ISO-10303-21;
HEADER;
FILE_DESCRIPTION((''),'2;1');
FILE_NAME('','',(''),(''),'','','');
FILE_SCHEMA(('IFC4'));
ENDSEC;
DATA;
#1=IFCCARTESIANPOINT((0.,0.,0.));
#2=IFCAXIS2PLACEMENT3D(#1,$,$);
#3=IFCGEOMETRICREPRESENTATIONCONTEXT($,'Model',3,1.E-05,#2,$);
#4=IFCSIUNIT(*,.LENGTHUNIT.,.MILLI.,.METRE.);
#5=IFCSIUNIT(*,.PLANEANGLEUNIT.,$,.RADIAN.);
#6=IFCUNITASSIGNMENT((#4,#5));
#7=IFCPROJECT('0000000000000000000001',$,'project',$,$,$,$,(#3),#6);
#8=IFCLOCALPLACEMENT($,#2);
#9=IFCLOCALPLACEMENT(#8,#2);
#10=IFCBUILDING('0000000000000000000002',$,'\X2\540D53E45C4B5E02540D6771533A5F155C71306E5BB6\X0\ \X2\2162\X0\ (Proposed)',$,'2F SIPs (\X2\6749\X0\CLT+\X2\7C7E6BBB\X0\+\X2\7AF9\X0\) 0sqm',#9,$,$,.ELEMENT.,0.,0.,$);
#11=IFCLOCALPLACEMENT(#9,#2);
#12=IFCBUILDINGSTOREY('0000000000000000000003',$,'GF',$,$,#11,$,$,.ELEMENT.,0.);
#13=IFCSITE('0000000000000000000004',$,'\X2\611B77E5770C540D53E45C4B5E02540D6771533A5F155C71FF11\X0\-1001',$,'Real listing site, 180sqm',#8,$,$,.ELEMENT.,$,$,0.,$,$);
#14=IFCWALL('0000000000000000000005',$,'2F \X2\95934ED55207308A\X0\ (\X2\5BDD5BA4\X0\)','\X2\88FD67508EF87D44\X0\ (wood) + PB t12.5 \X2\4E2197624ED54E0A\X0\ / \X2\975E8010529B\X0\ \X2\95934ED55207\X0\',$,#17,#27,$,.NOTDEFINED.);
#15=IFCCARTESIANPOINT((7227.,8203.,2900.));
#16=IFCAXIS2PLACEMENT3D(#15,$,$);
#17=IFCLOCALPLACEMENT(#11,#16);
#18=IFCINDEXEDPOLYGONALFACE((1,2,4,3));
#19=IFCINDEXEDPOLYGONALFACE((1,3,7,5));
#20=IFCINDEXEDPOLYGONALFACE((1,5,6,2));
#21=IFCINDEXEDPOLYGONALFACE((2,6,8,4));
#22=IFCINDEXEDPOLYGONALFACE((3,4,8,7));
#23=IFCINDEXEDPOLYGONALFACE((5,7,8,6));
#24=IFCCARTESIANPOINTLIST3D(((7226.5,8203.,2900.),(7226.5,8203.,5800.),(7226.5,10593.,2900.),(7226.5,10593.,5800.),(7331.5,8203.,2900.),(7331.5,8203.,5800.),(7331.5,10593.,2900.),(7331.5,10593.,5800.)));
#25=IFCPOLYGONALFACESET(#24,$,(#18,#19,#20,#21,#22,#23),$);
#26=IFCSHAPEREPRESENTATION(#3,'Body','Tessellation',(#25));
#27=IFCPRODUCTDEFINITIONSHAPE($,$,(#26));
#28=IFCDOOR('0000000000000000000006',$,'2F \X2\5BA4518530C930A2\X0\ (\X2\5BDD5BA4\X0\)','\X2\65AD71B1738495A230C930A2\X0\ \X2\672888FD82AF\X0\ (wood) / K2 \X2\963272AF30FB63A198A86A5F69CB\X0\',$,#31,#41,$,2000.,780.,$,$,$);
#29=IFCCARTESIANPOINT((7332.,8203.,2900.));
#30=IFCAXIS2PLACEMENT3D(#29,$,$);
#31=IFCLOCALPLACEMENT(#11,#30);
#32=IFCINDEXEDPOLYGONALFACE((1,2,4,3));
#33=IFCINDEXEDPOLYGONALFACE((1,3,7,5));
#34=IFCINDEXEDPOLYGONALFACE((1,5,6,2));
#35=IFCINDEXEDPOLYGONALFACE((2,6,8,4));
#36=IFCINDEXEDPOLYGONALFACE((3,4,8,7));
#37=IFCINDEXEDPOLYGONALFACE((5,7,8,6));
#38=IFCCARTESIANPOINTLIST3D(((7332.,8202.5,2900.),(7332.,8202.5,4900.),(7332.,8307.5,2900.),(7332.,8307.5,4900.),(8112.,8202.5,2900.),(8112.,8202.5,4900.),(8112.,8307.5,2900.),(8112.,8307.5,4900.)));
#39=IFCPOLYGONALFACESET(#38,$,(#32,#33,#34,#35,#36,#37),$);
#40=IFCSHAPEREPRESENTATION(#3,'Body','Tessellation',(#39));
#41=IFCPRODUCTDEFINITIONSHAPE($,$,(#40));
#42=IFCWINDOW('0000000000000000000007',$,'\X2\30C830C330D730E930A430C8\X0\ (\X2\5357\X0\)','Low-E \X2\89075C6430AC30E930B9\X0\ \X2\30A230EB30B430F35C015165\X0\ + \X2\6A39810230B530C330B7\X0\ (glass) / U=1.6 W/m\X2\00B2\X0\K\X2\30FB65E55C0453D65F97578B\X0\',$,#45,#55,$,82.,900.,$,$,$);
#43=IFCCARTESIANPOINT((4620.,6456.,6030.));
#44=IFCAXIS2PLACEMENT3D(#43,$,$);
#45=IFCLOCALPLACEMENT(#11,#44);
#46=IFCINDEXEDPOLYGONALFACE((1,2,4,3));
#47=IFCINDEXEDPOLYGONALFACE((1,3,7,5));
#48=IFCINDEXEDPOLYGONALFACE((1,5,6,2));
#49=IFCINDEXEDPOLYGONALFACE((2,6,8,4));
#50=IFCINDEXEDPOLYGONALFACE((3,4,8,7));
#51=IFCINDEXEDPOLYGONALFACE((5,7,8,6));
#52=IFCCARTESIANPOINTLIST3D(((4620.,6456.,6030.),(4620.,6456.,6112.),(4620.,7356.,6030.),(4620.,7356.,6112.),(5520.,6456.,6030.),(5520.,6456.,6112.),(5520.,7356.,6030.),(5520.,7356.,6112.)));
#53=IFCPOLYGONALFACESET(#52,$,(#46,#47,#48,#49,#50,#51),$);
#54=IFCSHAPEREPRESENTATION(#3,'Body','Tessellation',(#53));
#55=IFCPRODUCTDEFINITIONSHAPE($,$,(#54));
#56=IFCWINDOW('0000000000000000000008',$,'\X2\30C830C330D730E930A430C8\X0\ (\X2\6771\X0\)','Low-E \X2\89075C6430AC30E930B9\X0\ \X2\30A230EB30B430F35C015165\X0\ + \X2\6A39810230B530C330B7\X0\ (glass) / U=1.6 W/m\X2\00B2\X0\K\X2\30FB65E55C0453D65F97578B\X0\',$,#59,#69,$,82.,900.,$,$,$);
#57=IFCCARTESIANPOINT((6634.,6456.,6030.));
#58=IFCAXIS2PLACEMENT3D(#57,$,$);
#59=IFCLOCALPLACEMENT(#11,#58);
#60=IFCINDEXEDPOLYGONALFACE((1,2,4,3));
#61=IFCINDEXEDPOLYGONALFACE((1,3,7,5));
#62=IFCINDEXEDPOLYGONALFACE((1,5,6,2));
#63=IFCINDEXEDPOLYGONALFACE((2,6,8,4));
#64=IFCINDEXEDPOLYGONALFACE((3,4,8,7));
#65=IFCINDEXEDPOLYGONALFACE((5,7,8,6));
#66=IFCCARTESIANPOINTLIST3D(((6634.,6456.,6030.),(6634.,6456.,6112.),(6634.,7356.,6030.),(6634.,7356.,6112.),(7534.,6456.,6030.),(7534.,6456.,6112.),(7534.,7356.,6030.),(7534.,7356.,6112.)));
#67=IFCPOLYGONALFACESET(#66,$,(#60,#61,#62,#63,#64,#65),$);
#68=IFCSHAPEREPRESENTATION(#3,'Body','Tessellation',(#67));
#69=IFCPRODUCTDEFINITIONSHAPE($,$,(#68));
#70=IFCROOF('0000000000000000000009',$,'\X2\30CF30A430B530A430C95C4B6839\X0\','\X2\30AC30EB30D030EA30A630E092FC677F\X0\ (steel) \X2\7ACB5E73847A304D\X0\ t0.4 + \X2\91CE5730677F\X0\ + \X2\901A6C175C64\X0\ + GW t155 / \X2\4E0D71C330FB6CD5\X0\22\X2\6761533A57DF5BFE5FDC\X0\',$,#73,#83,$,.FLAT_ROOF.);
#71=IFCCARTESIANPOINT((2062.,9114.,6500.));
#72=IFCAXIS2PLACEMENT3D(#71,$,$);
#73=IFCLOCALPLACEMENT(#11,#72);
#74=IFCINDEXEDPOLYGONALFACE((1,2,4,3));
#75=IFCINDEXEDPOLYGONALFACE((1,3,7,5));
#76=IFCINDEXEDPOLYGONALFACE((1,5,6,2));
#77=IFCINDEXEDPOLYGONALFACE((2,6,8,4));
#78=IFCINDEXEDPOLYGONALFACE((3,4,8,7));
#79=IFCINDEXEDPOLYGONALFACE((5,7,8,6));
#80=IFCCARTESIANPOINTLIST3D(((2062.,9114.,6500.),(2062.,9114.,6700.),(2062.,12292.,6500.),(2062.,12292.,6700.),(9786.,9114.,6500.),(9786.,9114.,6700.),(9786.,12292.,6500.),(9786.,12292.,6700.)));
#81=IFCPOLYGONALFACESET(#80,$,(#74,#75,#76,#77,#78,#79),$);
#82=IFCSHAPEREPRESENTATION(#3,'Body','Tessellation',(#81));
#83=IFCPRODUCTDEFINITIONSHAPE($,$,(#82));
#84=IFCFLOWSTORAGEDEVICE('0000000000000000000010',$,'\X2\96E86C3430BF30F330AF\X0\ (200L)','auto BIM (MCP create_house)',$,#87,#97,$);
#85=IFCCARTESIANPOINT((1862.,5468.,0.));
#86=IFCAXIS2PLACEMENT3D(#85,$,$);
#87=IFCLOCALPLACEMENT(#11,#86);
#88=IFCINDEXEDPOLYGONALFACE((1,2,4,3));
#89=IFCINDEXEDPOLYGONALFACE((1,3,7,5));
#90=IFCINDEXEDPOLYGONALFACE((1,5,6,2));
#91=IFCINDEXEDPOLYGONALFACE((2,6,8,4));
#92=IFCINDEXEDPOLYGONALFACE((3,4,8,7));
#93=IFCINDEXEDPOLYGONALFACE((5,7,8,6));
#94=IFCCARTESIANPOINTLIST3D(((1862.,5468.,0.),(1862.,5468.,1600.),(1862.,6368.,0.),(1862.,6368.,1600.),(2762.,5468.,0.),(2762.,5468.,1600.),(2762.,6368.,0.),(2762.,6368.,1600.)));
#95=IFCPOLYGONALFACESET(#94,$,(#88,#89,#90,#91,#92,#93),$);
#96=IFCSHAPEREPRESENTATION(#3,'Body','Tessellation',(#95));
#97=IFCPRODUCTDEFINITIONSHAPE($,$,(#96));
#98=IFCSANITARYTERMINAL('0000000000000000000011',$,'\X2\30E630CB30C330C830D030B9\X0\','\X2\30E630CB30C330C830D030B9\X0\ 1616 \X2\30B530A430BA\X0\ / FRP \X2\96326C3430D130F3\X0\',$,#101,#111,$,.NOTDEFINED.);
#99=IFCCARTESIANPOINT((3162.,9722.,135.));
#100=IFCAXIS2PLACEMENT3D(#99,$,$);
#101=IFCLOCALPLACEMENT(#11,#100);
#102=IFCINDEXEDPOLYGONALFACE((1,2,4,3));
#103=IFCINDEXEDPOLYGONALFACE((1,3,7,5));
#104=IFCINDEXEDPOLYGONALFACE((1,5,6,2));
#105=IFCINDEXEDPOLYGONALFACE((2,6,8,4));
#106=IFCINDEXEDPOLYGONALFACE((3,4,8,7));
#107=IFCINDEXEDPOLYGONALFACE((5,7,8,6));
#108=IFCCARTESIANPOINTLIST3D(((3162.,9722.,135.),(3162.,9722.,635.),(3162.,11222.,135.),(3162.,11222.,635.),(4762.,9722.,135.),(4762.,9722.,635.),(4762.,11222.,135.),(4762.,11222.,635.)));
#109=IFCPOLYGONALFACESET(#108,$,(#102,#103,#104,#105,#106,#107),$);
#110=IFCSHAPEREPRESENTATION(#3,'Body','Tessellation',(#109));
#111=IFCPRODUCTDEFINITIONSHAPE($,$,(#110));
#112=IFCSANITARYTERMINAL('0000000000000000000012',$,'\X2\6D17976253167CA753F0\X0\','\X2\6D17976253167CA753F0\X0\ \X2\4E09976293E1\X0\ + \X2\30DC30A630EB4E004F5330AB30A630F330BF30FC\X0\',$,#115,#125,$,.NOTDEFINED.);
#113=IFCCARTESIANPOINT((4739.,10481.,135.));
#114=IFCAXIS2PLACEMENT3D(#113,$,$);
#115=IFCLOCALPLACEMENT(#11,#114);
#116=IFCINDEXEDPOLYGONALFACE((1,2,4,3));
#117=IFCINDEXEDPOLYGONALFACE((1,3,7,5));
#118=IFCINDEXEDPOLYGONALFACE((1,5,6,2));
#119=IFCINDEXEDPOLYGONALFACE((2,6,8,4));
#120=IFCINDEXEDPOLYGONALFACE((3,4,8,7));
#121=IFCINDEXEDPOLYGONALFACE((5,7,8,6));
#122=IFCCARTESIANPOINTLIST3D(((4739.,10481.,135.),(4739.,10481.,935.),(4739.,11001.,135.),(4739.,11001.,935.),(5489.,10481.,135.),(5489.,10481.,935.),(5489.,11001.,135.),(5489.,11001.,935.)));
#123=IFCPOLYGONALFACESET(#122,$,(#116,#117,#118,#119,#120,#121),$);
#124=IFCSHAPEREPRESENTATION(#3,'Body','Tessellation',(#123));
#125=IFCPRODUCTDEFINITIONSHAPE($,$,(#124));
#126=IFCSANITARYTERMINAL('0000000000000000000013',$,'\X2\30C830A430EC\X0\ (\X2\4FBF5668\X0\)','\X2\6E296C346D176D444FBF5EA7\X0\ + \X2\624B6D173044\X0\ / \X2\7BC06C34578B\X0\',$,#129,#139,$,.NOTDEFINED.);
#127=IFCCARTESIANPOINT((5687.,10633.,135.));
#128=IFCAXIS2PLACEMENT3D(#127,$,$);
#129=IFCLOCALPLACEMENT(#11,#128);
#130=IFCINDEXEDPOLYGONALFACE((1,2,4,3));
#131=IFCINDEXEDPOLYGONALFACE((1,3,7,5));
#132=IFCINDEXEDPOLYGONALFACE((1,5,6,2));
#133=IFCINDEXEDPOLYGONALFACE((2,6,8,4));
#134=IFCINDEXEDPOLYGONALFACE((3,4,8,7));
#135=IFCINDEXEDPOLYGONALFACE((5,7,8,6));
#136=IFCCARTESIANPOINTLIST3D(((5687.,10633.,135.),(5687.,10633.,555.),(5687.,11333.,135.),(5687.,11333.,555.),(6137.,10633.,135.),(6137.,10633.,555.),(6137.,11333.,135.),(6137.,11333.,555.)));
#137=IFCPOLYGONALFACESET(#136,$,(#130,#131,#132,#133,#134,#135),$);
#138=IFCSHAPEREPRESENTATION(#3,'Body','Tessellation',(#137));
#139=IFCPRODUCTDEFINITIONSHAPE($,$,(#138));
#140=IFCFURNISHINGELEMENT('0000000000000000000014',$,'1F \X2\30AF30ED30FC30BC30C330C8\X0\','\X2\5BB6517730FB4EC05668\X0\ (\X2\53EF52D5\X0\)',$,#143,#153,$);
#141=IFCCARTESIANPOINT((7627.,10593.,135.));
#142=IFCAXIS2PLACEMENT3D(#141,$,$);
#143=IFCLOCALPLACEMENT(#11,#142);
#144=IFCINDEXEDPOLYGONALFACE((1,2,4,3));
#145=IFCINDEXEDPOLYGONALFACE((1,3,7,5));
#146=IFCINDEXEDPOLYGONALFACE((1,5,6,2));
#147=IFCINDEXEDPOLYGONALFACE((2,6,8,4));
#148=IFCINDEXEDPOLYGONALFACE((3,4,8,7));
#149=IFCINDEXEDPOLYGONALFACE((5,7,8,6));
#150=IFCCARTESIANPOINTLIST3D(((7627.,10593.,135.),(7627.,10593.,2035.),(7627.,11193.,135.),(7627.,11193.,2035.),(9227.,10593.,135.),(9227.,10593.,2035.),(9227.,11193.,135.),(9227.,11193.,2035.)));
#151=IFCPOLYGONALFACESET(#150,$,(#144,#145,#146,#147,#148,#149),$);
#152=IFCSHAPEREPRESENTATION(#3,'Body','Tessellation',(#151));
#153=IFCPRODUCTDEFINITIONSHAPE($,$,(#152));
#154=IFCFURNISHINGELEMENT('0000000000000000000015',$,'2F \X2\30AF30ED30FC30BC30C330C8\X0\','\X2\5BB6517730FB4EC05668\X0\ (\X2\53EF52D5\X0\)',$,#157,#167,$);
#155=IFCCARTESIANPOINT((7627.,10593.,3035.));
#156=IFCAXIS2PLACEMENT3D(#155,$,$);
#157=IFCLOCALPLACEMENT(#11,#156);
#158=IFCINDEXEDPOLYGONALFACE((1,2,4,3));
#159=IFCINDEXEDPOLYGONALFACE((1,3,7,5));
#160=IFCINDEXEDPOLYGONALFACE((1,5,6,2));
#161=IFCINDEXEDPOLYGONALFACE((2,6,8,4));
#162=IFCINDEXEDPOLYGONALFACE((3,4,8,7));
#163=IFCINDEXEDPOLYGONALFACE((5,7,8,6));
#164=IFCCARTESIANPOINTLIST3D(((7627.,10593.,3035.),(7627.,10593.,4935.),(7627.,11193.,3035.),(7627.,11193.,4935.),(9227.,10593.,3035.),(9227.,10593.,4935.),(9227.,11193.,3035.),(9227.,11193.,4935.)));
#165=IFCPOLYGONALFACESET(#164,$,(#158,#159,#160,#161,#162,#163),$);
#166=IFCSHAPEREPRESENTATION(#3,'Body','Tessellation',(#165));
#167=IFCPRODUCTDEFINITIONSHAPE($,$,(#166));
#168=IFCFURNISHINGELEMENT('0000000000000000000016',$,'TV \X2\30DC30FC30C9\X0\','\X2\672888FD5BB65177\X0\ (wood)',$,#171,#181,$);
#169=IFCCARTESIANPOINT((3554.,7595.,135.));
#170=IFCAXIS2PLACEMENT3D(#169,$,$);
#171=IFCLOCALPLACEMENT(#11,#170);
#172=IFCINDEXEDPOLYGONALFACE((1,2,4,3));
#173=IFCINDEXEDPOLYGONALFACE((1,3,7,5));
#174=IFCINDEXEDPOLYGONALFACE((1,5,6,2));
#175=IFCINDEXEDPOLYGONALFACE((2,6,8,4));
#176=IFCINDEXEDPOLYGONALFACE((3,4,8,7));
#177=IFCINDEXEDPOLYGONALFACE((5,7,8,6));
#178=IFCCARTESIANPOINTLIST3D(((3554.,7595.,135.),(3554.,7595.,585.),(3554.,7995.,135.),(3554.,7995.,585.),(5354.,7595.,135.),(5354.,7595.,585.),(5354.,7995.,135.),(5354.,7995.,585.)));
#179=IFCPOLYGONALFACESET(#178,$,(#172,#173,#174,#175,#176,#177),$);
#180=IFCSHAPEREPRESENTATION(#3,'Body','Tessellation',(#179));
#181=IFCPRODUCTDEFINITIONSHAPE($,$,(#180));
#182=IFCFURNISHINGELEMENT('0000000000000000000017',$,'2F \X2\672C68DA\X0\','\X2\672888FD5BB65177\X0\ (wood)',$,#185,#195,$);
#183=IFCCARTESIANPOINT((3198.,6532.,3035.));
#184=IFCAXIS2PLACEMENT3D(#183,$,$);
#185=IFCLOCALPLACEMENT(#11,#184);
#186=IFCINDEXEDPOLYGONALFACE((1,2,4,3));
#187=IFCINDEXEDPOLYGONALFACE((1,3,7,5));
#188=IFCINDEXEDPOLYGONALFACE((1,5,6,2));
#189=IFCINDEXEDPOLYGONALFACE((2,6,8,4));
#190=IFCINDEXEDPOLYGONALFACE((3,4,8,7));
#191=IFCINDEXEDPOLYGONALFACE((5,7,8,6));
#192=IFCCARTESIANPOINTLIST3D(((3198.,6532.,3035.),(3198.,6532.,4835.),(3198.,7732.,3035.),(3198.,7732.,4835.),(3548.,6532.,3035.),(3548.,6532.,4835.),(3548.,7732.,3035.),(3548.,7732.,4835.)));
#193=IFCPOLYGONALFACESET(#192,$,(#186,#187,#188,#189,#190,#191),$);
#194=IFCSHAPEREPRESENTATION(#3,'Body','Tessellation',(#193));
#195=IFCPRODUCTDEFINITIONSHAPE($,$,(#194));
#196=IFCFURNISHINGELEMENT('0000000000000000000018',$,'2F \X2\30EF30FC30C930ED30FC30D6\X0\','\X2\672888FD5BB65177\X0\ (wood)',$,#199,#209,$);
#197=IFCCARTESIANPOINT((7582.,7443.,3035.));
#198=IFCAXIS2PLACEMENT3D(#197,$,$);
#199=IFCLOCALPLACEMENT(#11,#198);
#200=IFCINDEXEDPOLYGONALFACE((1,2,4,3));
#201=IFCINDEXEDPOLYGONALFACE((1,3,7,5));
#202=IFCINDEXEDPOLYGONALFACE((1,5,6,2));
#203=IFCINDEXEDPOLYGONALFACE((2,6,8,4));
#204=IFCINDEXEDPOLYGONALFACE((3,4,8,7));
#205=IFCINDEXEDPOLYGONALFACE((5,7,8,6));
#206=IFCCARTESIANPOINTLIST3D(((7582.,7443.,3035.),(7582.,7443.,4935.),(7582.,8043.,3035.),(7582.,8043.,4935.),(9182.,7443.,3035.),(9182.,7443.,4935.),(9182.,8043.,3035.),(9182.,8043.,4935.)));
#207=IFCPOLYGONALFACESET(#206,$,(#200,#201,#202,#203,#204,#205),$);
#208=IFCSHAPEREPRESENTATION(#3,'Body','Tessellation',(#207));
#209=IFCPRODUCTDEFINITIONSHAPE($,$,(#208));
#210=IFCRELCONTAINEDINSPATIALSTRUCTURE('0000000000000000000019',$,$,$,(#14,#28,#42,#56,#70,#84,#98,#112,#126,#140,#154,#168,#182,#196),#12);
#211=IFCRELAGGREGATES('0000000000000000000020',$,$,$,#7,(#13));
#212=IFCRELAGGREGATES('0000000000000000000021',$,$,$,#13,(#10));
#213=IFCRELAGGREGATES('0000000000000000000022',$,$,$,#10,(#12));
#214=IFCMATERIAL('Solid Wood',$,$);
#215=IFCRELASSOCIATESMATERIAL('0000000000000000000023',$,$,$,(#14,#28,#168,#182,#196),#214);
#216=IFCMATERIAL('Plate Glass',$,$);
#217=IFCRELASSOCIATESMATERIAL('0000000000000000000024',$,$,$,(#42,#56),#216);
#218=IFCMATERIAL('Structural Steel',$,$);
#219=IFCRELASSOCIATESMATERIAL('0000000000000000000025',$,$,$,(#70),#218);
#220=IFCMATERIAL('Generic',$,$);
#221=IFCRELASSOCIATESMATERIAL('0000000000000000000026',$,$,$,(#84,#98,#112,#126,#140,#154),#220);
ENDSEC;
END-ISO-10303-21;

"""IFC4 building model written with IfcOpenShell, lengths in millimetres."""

from ifc_helpers import new_model, si_unit, frame, frame_2d, origin, place, context, project, spatial, rectangle, extrude, material, element, save


model = new_model("IFC4")

# Units and contexts
model_context = context("Model", 3, precision=1e-05, world=origin())
ifc_project = project(units=[si_unit("LENGTHUNIT", "METRE", prefix="MILLI"), si_unit("PLANEANGLEUNIT", "RADIAN")], contexts=[model_context])

# Site, building, storey
site_placement = place(None, origin())
site = spatial("IfcSite", under=ifc_project, at=site_placement, Name="愛知県名古屋市名東区引山１-1001", ObjectType="Real listing site, 180sqm", CompositionType="ELEMENT", RefElevation=0.0)
building_placement = place(site_placement, origin())
building = spatial("IfcBuilding", under=site, at=building_placement, Name="名古屋市名東区引山の家 Ⅲ (Proposed)", ObjectType="2F SIPs (杉CLT+籾殻+竹) 0sqm", CompositionType="ELEMENT", ElevationOfRefHeight=0.0, ElevationOfTerrain=0.0)
storey_placement = place(building_placement, origin())
storey = spatial("IfcBuildingStorey", under=building, at=storey_placement, Name="GF", CompositionType="ELEMENT", Elevation=0.0)

# Shared definitions
ifc_material_1 = material(Name="Solid Wood")
ifc_material_2 = material(Name="Plate Glass")

# Wall
wall_1_placement = place(storey_placement, frame((7227.0, 8203.0, 2900.0)))
element("IfcWall", 1, at=wall_1_placement, inside=storey, material=ifc_material_1, Name="2F 間仕切り (寝室)", Description="製材軸組 (wood) + PB t12.5 両面仕上 / 非耐力 間仕切", PredefinedType="NOTDEFINED", context=model_context, shape_type="SweptSolid", body=[
    extrude(rectangle(XDim=105.0, YDim=2390.0, at=frame_2d((52.0, 1195.0))), frame((7227.0, 8203.0, 2900.0)), (0.0, 0.0, 1.0), 2900.0),
])

# Door
door_1_placement = place(storey_placement, frame((7332.0, 8203.0, 2900.0)))
element("IfcDoor", 2, at=door_1_placement, inside=storey, material=ifc_material_1, Name="2F 室内ドア (寝室)", Description="断熱玄関ドア 木製芯 (wood) / K2 防犯・採風機構", OverallHeight=2000.0, OverallWidth=780.0, context=model_context, shape_type="SweptSolid", body=[
    extrude(rectangle(XDim=780.0, YDim=105.0, at=frame_2d((390.0, 52.0))), frame((7332.0, 8203.0, 2900.0)), (0.0, 0.0, 1.0), 2000.0),
])

# Windows
window_1_placement = place(storey_placement, frame((4620.0, 6456.0, 6030.0)))
element("IfcWindow", 3, at=window_1_placement, inside=storey, material=ifc_material_2, Name="トップライト (南)", Description="Low-E 複層ガラス アルゴン封入 + 樹脂サッシ (glass) / U=1.6 W/m²K・日射取得型", OverallHeight=82.0, OverallWidth=900.0, context=model_context, shape_type="SweptSolid", body=[
    extrude(rectangle(XDim=900.0, YDim=900.0, at=frame_2d((450.0, 450.0))), frame((4620.0, 6456.0, 6030.0)), (0.0, 0.0, 1.0), 82.0),
])
window_2_placement = place(storey_placement, frame((6634.0, 6456.0, 6030.0)))
element("IfcWindow", 4, at=window_2_placement, inside=storey, material=ifc_material_2, Name="トップライト (東)", Description="Low-E 複層ガラス アルゴン封入 + 樹脂サッシ (glass) / U=1.6 W/m²K・日射取得型", OverallHeight=82.0, OverallWidth=900.0, context=model_context, shape_type="SweptSolid", body=[
    extrude(rectangle(XDim=900.0, YDim=900.0, at=frame_2d((450.0, 450.0))), frame((6634.0, 6456.0, 6030.0)), (0.0, 0.0, 1.0), 82.0),
])

# Roof
ifc_material_3 = material(Name="Structural Steel")
roof_placement = place(storey_placement, frame((2062.0, 9114.0, 6500.0)))
element("IfcRoof", 5, at=roof_placement, inside=storey, material=ifc_material_3, Name="ハイサイド屋根", Description="ガルバリウム鋼板 (steel) 立平葺き t0.4 + 野地板 + 通気層 + GW t155 / 不燃・法22条区域対応", PredefinedType="FLAT_ROOF", context=model_context, shape_type="SweptSolid", body=[
    extrude(rectangle(XDim=7724.0, YDim=3178.0, at=frame_2d((3862.0, 1589.0))), frame((2062.0, 9114.0, 6500.0)), (0.0, 0.0, 1.0), 200.0),
])

# Flow storage device
ifc_material_4 = material(Name="Generic")
flow_storage_device_placement = place(storey_placement, frame((1862.0, 5468.0, 0.0)))
element("IfcFlowStorageDevice", 6, at=flow_storage_device_placement, inside=storey, material=ifc_material_4, Name="雨水タンク (200L)", Description="auto BIM (MCP create_house)", context=model_context, shape_type="SweptSolid", body=[
    extrude(rectangle(XDim=900.0, YDim=900.0, at=frame_2d((450.0, 450.0))), frame((1862.0, 5468.0, 0.0)), (0.0, 0.0, 1.0), 1600.0),
])

# Sanitary terminals
sanitary_terminal_1_placement = place(storey_placement, frame((3162.0, 9722.0, 135.0)))
element("IfcSanitaryTerminal", 7, at=sanitary_terminal_1_placement, inside=storey, material=ifc_material_4, Name="ユニットバス", Description="ユニットバス 1616 サイズ / FRP 防水パン", PredefinedType="NOTDEFINED", context=model_context, shape_type="SweptSolid", body=[
    extrude(rectangle(XDim=1600.0, YDim=1500.0, at=frame_2d((800.0, 750.0))), frame((3162.0, 9722.0, 135.0)), (0.0, 0.0, 1.0), 500.0),
])
sanitary_terminal_2_placement = place(storey_placement, frame((4739.0, 10481.0, 135.0)))
element("IfcSanitaryTerminal", 8, at=sanitary_terminal_2_placement, inside=storey, material=ifc_material_4, Name="洗面化粧台", Description="洗面化粧台 三面鏡 + ボウル一体カウンター", PredefinedType="NOTDEFINED", context=model_context, shape_type="SweptSolid", body=[
    extrude(rectangle(XDim=750.0, YDim=520.0, at=frame_2d((375.0, 260.0))), frame((4739.0, 10481.0, 135.0)), (0.0, 0.0, 1.0), 800.0),
])
sanitary_terminal_3_placement = place(storey_placement, frame((5687.0, 10633.0, 135.0)))
element("IfcSanitaryTerminal", 9, at=sanitary_terminal_3_placement, inside=storey, material=ifc_material_4, Name="トイレ (便器)", Description="温水洗浄便座 + 手洗い / 節水型", PredefinedType="NOTDEFINED", context=model_context, shape_type="SweptSolid", body=[
    extrude(rectangle(XDim=450.0, YDim=700.0, at=frame_2d((225.0, 350.0))), frame((5687.0, 10633.0, 135.0)), (0.0, 0.0, 1.0), 420.0),
])

# Furnishing elements
furnishing_1_placement = place(storey_placement, frame((7627.0, 10593.0, 135.0)))
element("IfcFurnishingElement", 10, at=furnishing_1_placement, inside=storey, material=ifc_material_4, Name="1F クローゼット", Description="家具・什器 (可動)", context=model_context, shape_type="SweptSolid", body=[
    extrude(rectangle(XDim=1600.0, YDim=600.0, at=frame_2d((800.0, 300.0))), frame((7627.0, 10593.0, 135.0)), (0.0, 0.0, 1.0), 1900.0),
])
furnishing_2_placement = place(storey_placement, frame((7627.0, 10593.0, 3035.0)))
element("IfcFurnishingElement", 11, at=furnishing_2_placement, inside=storey, material=ifc_material_4, Name="2F クローゼット", Description="家具・什器 (可動)", context=model_context, shape_type="SweptSolid", body=[
    extrude(rectangle(XDim=1600.0, YDim=600.0, at=frame_2d((800.0, 300.0))), frame((7627.0, 10593.0, 3035.0)), (0.0, 0.0, 1.0), 1900.0),
])
furnishing_3_placement = place(storey_placement, frame((3554.0, 7595.0, 135.0)))
element("IfcFurnishingElement", 12, at=furnishing_3_placement, inside=storey, material=ifc_material_1, Name="TV ボード", Description="木製家具 (wood)", context=model_context, shape_type="SweptSolid", body=[
    extrude(rectangle(XDim=1800.0, YDim=400.0, at=frame_2d((900.0, 200.0))), frame((3554.0, 7595.0, 135.0)), (0.0, 0.0, 1.0), 450.0),
])
furnishing_4_placement = place(storey_placement, frame((3198.0, 6532.0, 3035.0)))
element("IfcFurnishingElement", 13, at=furnishing_4_placement, inside=storey, material=ifc_material_1, Name="2F 本棚", Description="木製家具 (wood)", context=model_context, shape_type="SweptSolid", body=[
    extrude(rectangle(XDim=350.0, YDim=1200.0, at=frame_2d((175.0, 600.0))), frame((3198.0, 6532.0, 3035.0)), (0.0, 0.0, 1.0), 1800.0),
])
furnishing_5_placement = place(storey_placement, frame((7582.0, 7443.0, 3035.0)))
element("IfcFurnishingElement", 14, at=furnishing_5_placement, inside=storey, material=ifc_material_1, Name="2F ワードローブ", Description="木製家具 (wood)", context=model_context, shape_type="SweptSolid", body=[
    extrude(rectangle(XDim=1600.0, YDim=600.0, at=frame_2d((800.0, 300.0))), frame((7582.0, 7443.0, 3035.0)), (0.0, 0.0, 1.0), 1900.0),
])

save(model, "model.ifc")
